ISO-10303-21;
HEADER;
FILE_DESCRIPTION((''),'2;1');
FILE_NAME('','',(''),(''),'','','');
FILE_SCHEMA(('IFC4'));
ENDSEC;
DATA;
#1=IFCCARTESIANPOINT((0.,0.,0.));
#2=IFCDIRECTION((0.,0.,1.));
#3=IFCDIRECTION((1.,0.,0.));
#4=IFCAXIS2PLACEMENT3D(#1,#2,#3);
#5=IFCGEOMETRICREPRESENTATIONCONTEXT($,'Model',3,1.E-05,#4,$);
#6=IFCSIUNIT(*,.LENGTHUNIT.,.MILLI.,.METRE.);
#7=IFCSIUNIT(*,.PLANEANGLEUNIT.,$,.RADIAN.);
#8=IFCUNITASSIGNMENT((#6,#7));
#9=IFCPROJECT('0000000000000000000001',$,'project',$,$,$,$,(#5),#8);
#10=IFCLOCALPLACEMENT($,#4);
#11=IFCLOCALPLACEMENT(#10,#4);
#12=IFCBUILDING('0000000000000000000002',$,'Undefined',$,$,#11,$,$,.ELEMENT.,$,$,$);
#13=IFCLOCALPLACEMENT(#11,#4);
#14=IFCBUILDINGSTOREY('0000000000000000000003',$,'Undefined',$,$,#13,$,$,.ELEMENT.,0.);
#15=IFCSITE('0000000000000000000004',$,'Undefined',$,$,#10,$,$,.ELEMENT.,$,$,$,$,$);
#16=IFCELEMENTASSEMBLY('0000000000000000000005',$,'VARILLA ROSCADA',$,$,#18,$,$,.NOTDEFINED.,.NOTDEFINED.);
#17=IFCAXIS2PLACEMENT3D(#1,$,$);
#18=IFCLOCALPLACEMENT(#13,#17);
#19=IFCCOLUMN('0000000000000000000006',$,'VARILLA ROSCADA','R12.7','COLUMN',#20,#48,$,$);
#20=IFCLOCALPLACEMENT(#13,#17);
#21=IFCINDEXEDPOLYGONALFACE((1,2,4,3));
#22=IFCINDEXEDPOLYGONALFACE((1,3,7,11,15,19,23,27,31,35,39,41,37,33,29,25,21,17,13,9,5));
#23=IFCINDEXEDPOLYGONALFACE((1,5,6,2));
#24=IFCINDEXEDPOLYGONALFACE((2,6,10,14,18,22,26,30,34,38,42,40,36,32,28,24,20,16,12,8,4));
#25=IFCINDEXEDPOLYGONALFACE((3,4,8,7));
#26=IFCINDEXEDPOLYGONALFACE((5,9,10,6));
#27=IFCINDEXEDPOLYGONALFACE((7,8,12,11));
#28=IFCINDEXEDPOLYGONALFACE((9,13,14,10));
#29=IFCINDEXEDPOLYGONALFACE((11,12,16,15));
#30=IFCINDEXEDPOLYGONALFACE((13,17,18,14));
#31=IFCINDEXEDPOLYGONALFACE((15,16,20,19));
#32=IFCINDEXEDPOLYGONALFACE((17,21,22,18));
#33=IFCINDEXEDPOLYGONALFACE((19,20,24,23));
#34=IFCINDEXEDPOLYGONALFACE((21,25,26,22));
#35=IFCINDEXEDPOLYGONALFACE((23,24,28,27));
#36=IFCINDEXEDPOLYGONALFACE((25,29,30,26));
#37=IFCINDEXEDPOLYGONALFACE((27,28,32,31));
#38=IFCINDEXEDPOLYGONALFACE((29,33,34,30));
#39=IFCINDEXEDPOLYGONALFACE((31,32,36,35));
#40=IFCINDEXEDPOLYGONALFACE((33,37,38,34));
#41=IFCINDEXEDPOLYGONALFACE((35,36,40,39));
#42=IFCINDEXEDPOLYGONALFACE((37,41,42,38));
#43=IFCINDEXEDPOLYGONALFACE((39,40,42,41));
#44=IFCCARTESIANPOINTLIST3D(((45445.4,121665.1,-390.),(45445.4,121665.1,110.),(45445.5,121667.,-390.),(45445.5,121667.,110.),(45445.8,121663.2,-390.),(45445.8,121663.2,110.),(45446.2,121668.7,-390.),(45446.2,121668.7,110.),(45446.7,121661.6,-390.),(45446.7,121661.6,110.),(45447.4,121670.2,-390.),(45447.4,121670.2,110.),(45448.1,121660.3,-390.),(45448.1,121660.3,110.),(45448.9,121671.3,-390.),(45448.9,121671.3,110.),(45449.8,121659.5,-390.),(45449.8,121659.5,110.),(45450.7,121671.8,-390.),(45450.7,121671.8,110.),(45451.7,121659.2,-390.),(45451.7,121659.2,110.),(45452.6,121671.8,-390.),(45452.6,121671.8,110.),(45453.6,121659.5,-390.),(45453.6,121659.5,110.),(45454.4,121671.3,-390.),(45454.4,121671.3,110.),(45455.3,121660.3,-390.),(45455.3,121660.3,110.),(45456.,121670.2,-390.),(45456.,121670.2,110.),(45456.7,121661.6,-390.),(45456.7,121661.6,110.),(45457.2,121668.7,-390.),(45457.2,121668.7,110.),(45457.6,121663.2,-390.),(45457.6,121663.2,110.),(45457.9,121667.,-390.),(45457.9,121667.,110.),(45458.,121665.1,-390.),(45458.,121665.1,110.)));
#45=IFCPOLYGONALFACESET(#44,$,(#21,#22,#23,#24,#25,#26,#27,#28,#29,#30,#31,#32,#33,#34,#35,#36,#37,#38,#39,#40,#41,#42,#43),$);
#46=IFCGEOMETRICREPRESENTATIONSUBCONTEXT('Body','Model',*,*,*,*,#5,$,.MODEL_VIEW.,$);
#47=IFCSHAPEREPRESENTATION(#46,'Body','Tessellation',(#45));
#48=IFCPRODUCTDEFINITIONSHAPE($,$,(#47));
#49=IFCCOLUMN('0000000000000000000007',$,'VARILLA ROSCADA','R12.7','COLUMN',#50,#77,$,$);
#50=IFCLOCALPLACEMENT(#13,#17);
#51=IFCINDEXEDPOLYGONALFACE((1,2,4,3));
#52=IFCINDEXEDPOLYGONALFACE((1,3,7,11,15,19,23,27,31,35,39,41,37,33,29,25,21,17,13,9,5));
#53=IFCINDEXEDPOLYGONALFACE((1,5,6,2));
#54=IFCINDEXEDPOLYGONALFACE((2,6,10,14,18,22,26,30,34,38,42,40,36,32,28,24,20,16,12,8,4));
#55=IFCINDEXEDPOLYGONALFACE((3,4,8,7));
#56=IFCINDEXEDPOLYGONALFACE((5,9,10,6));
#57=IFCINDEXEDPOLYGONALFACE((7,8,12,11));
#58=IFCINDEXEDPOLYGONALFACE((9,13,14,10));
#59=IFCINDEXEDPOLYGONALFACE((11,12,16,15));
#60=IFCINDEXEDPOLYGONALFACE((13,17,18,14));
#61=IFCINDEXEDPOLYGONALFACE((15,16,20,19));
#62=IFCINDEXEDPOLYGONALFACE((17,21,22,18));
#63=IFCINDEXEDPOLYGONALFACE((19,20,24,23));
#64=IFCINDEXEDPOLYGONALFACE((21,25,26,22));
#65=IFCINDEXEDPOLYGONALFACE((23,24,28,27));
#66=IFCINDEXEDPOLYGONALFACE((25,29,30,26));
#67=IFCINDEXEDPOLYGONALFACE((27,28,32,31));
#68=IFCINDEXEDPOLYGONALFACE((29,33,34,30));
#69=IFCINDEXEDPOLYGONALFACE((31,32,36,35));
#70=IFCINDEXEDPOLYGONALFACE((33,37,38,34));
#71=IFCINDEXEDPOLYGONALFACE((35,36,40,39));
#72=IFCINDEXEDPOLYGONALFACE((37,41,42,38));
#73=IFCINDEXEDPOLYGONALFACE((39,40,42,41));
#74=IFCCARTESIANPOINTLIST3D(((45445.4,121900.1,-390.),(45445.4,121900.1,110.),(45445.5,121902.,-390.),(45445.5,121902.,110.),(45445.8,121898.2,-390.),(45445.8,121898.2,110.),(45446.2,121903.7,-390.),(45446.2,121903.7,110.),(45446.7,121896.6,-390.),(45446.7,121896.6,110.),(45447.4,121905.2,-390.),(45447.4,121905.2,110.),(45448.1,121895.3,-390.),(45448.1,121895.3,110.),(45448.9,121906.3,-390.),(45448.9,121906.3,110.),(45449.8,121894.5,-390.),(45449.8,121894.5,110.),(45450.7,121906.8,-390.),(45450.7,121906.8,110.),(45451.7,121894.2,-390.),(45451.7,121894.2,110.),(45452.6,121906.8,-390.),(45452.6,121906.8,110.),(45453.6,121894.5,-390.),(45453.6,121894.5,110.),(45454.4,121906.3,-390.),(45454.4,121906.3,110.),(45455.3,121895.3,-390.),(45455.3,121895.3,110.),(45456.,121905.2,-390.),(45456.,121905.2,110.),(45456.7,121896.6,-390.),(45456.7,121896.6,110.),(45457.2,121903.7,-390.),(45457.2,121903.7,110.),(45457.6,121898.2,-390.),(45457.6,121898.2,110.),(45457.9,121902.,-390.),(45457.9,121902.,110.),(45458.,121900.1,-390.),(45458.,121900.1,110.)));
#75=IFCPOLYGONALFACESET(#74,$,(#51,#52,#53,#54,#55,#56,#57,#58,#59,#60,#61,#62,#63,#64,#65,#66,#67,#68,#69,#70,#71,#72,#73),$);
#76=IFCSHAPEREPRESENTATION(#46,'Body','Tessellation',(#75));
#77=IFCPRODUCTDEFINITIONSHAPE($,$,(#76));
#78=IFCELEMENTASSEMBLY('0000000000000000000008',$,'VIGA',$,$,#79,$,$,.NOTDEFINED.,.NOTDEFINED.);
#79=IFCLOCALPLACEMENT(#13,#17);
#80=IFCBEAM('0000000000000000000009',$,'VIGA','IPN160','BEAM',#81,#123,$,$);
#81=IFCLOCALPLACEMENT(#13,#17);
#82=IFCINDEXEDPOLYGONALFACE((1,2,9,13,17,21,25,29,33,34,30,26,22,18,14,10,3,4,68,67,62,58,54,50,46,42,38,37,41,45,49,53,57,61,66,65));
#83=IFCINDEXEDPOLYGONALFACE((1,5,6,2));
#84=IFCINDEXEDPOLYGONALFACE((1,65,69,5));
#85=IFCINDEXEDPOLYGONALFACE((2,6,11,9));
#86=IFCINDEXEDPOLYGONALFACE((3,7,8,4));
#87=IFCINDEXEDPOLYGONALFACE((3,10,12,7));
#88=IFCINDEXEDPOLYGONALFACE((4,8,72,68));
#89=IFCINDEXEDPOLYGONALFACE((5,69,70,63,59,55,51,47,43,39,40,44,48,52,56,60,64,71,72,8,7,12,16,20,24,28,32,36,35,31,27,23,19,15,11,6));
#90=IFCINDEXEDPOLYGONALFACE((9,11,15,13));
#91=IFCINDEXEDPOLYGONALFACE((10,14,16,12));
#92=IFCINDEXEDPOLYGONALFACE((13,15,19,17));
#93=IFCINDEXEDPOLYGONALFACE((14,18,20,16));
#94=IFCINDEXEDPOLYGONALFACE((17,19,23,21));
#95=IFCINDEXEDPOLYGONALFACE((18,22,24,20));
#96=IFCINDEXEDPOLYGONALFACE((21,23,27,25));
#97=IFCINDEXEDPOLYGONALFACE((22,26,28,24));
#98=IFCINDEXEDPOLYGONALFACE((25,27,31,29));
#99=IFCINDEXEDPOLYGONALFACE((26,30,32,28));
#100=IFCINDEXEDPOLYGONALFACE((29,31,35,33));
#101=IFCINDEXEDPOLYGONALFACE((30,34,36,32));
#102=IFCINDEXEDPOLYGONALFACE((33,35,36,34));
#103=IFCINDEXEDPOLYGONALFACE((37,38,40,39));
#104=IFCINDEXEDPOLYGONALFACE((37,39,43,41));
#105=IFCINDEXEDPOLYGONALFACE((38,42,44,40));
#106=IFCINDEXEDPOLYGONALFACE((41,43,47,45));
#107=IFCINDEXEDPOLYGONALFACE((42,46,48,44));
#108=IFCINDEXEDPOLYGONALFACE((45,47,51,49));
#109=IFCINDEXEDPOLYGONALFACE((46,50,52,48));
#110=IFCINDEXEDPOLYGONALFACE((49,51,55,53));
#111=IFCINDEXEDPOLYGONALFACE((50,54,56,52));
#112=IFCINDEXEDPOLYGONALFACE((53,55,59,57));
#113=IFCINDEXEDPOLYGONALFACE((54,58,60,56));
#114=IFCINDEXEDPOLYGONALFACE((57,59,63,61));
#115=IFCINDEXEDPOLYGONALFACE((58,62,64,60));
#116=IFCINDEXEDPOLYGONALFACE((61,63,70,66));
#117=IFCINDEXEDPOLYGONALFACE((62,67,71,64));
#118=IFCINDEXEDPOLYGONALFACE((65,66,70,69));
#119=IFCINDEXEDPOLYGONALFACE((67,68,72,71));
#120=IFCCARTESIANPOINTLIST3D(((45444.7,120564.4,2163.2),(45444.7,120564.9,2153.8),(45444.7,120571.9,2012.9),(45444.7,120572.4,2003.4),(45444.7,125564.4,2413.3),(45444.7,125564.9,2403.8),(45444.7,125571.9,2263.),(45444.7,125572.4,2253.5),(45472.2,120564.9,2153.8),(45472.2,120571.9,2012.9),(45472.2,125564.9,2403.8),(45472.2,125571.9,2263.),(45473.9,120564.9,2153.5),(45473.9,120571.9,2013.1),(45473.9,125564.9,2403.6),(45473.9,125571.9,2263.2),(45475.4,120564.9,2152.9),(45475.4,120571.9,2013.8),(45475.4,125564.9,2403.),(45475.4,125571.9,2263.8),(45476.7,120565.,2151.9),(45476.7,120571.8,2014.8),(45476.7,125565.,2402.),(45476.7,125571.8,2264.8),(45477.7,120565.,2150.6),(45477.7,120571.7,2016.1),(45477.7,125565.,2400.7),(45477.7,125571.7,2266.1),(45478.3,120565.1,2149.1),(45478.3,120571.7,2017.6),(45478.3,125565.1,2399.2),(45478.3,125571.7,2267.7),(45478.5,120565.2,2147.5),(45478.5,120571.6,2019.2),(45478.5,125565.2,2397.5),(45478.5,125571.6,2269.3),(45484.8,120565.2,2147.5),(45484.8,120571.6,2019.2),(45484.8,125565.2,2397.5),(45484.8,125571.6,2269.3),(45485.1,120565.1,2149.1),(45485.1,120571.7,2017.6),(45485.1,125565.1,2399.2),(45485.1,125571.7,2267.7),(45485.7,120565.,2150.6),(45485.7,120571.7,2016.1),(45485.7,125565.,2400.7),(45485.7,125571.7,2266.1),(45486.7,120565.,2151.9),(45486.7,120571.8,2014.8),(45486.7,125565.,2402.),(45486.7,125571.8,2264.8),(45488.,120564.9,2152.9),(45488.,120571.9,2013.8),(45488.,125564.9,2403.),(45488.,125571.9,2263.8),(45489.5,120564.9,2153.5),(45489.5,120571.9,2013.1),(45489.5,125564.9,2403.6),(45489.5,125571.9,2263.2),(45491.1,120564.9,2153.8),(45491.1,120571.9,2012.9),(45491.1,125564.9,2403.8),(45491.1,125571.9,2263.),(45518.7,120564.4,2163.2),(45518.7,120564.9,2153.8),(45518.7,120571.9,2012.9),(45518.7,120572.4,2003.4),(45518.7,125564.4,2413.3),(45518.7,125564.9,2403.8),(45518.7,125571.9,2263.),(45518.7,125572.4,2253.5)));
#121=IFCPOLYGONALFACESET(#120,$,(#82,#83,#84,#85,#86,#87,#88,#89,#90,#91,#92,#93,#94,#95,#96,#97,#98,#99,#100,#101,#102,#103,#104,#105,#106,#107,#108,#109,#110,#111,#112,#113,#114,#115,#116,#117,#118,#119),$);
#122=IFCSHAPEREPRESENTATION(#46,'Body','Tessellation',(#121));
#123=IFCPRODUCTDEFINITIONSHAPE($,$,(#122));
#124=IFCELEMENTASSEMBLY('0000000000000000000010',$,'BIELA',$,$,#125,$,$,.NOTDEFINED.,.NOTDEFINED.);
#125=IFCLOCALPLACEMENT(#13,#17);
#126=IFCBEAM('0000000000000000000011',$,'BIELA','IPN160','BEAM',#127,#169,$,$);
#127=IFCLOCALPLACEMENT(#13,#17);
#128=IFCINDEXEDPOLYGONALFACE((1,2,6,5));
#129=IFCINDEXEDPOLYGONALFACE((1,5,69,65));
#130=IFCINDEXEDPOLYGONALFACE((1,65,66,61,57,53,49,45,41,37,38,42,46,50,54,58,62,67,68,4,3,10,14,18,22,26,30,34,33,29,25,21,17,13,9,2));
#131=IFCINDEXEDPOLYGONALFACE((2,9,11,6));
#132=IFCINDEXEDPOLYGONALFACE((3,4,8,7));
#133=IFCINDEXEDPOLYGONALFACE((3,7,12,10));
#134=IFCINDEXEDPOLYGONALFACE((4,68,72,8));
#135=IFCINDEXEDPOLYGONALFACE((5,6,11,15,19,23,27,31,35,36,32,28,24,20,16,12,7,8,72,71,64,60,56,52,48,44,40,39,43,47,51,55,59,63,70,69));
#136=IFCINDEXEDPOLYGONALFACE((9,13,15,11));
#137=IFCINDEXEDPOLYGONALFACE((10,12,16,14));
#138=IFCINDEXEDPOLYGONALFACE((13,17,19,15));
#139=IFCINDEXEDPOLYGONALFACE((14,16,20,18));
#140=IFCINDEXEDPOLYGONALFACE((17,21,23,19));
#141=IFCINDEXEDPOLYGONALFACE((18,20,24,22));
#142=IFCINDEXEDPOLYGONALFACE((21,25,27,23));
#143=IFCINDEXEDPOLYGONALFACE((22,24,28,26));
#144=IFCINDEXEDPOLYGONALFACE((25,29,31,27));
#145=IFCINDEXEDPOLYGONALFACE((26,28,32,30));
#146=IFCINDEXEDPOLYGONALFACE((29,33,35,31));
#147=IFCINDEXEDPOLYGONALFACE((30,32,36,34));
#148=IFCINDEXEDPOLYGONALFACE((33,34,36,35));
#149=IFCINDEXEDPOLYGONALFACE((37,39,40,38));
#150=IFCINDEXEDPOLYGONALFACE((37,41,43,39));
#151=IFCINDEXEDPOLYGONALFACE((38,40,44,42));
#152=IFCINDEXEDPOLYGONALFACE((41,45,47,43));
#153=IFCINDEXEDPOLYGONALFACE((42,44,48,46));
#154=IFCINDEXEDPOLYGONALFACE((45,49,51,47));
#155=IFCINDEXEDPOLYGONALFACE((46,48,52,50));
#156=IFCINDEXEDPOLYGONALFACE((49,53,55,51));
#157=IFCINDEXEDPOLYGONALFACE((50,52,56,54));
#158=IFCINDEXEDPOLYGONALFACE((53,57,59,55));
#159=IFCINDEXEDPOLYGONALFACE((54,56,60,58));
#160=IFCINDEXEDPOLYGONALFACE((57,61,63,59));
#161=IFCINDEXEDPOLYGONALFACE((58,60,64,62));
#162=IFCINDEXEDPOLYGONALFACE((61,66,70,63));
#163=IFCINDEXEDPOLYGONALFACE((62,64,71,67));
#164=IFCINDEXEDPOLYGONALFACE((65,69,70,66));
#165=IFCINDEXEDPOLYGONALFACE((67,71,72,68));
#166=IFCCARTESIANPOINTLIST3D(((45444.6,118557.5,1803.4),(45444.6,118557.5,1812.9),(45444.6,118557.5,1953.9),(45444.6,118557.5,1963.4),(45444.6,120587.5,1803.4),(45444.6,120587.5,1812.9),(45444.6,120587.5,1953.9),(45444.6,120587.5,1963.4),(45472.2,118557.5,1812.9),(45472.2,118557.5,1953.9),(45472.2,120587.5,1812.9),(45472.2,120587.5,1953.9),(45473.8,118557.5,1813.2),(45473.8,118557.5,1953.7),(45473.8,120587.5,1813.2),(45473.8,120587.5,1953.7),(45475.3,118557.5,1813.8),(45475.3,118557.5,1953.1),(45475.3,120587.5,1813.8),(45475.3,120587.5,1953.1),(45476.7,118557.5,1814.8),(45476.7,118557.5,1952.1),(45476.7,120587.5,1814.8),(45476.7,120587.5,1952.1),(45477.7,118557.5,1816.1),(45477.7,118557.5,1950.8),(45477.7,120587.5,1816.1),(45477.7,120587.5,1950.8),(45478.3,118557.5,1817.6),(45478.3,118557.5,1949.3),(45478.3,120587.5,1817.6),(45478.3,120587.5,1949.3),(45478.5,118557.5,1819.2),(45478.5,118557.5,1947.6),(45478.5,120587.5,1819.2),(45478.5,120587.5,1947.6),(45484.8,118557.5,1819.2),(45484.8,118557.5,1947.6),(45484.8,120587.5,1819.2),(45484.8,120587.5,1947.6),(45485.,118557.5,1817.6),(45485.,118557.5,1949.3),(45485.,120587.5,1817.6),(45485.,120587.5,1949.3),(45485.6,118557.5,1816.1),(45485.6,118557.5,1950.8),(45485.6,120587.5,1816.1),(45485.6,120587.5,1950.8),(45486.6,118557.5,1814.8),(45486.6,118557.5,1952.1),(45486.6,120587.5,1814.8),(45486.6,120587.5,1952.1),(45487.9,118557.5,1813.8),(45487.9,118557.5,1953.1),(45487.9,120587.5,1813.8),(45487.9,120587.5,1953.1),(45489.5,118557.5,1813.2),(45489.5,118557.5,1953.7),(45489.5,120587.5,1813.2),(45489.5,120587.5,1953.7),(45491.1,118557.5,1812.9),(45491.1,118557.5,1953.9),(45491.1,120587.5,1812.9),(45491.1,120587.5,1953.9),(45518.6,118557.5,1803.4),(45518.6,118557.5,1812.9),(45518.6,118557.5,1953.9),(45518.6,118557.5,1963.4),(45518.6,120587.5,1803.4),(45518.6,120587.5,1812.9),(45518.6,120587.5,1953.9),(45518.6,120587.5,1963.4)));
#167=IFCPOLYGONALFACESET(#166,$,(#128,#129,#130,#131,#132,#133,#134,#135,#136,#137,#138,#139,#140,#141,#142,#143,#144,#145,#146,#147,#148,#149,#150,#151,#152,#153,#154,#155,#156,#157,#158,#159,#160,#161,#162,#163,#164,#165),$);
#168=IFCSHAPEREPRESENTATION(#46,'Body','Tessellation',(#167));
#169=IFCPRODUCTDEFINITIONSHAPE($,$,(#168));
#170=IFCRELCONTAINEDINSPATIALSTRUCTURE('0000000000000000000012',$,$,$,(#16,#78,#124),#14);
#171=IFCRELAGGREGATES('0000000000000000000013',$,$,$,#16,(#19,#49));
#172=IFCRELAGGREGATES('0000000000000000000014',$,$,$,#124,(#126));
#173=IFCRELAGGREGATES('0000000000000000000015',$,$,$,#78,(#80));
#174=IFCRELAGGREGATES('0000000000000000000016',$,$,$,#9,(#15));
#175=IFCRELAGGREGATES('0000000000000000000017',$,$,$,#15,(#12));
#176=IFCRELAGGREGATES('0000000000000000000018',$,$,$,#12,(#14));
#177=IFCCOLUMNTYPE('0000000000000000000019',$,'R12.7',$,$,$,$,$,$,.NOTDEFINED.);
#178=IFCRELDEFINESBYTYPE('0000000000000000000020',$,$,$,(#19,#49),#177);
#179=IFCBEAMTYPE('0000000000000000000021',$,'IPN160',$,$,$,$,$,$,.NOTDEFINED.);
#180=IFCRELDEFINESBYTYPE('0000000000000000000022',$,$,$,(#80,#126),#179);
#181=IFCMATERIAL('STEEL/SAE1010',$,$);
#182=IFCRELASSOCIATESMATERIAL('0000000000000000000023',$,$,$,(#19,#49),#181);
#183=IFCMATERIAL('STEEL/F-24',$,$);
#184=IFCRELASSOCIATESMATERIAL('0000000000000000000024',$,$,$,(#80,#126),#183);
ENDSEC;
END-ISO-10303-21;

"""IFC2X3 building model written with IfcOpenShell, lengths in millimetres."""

from ifc_helpers import new_model, si_unit, frame, origin_with_axes, origin_2d_with_axis, place, context, subcontext, project, spatial, circle, i_section, extrude, material, type_object, element, aggregate, save


model = new_model("IFC2X3")

# Units and contexts
model_context = context("Model", 3, precision=1e-05, world=origin_with_axes())
body_context = subcontext(model_context, "Body", "Model", "MODEL_VIEW")
ifc_project = project(units=[si_unit("LENGTHUNIT", "METRE", prefix="MILLI"), si_unit("PLANEANGLEUNIT", "RADIAN")], contexts=[model_context])

# Site, building, storey
site_placement = place(None, origin_with_axes())
site = spatial("IfcSite", under=ifc_project, at=site_placement, Name="Undefined", CompositionType="ELEMENT")
building_placement = place(site_placement, origin_with_axes())
building = spatial("IfcBuilding", under=site, at=building_placement, Name="Undefined", CompositionType="ELEMENT")
storey_placement = place(building_placement, origin_with_axes())
storey = spatial("IfcBuildingStorey", under=building, at=storey_placement, Name="Undefined", CompositionType="ELEMENT", Elevation=0.0)

# Element assembly, columns
assembly_1_placement = place(storey_placement, origin_with_axes())
assembly_1 = element("IfcElementAssembly", 1, at=assembly_1_placement, inside=storey, Name="VARILLA ROSCADA", AssemblyPlace="NOTDEFINED", PredefinedType="NOTDEFINED")
ifc_material_1 = material(Name="STEEL/SAE1010")
column_type = type_object("IfcColumnType", Name="R12.7", PredefinedType="NOTDEFINED")
column_1_placement = place(assembly_1_placement, frame((45451.7, 121665.6, -390.0), z_axis=(0.0, 0.0, 1.0), x_axis=(-1.0, 0.0, 0.0)))
column_1 = element("IfcColumn", 2, at=column_1_placement, type_object=column_type, material=ifc_material_1, Name="VARILLA ROSCADA", Description="R12.7", ObjectType="COLUMN", context=body_context, shape_type="SweptSolid", body=[
    extrude(circle(Radius=6.3, at=origin_2d_with_axis()), frame((0.0, 0.0, 500.0), z_axis=(0.0, 0.0, -1.0), x_axis=(0.0, 1.0, 0.0)), (0.0, 0.0, 1.0), 500.0),
])
column_2_placement = place(assembly_1_placement, frame((45451.7, 121900.6, -390.0), z_axis=(0.0, 0.0, 1.0), x_axis=(-1.0, 0.0, 0.0)))
column_2 = element("IfcColumn", 3, at=column_2_placement, type_object=column_type, material=ifc_material_1, Name="VARILLA ROSCADA", Description="R12.7", ObjectType="COLUMN", context=body_context, shape_type="SweptSolid", body=[
    extrude(circle(Radius=6.3, at=origin_2d_with_axis()), frame((0.0, 0.0, 500.0), z_axis=(0.0, 0.0, -1.0), x_axis=(0.0, 1.0, 0.0)), (0.0, 0.0, 1.0), 500.0),
])

# Element assembly, beam
assembly_2_placement = place(storey_placement, origin_with_axes())
assembly_2 = element("IfcElementAssembly", 4, at=assembly_2_placement, inside=storey, Name="VIGA", AssemblyPlace="NOTDEFINED", PredefinedType="NOTDEFINED")
ifc_material_2 = material(Name="STEEL/F-24")
beam_type_1 = type_object("IfcBeamType", Name="IPN160", PredefinedType="NOTDEFINED")
beam_1_placement = place(assembly_2_placement, frame((45481.7, 120568.4, 2083.3), z_axis=(0.0, -0.04995, 0.998752), x_axis=(0.0, 0.998752, 0.04995)))
beam_1 = element("IfcBeam", 5, at=beam_1_placement, type_object=beam_type_1, material=ifc_material_2, Name="VIGA", Description="IPN160", ObjectType="BEAM", context=body_context, shape_type="SweptSolid", body=[
    extrude(i_section(OverallWidth=74.0, OverallDepth=160.0, WebThickness=6.3, FlangeThickness=9.5, FilletRadius=6.3, at=origin_2d_with_axis()), frame((5006.2, 0.0, 0.0), z_axis=(-1.0, 0.0, 0.0), x_axis=(0.0, -1.0, 0.0)), (0.0, 0.0, 1.0), 5006.2),
])

# Element assembly, beam
assembly_3_placement = place(storey_placement, origin_with_axes())
assembly_3 = element("IfcElementAssembly", 6, at=assembly_3_placement, inside=storey, Name="BIELA", AssemblyPlace="NOTDEFINED", PredefinedType="NOTDEFINED")
beam_2_placement = place(assembly_3_placement, frame((45481.6, 120587.5, 1883.4), z_axis=(0.0, 0.000002, 1.0), x_axis=(0.0, -1.0, 0.000002)))
beam_2 = element("IfcBeam", 7, at=beam_2_placement, type_object=beam_type_1, material=ifc_material_2, Name="BIELA", Description="IPN160", ObjectType="BEAM", context=body_context, shape_type="SweptSolid", body=[
    extrude(i_section(OverallWidth=74.0, OverallDepth=160.0, WebThickness=6.3, FlangeThickness=9.5, FilletRadius=6.3, at=origin_2d_with_axis()), frame((2030.0, 0.0, 0.0), z_axis=(-1.0, 0.0, 0.0), x_axis=(0.0, -1.0, 0.0)), (0.0, 0.0, 1.0), 2030.0),
])

aggregate(assembly_1, [column_1, column_2])
aggregate(assembly_3, [beam_2])
aggregate(assembly_2, [beam_1])

save(model, "model.ifc")
